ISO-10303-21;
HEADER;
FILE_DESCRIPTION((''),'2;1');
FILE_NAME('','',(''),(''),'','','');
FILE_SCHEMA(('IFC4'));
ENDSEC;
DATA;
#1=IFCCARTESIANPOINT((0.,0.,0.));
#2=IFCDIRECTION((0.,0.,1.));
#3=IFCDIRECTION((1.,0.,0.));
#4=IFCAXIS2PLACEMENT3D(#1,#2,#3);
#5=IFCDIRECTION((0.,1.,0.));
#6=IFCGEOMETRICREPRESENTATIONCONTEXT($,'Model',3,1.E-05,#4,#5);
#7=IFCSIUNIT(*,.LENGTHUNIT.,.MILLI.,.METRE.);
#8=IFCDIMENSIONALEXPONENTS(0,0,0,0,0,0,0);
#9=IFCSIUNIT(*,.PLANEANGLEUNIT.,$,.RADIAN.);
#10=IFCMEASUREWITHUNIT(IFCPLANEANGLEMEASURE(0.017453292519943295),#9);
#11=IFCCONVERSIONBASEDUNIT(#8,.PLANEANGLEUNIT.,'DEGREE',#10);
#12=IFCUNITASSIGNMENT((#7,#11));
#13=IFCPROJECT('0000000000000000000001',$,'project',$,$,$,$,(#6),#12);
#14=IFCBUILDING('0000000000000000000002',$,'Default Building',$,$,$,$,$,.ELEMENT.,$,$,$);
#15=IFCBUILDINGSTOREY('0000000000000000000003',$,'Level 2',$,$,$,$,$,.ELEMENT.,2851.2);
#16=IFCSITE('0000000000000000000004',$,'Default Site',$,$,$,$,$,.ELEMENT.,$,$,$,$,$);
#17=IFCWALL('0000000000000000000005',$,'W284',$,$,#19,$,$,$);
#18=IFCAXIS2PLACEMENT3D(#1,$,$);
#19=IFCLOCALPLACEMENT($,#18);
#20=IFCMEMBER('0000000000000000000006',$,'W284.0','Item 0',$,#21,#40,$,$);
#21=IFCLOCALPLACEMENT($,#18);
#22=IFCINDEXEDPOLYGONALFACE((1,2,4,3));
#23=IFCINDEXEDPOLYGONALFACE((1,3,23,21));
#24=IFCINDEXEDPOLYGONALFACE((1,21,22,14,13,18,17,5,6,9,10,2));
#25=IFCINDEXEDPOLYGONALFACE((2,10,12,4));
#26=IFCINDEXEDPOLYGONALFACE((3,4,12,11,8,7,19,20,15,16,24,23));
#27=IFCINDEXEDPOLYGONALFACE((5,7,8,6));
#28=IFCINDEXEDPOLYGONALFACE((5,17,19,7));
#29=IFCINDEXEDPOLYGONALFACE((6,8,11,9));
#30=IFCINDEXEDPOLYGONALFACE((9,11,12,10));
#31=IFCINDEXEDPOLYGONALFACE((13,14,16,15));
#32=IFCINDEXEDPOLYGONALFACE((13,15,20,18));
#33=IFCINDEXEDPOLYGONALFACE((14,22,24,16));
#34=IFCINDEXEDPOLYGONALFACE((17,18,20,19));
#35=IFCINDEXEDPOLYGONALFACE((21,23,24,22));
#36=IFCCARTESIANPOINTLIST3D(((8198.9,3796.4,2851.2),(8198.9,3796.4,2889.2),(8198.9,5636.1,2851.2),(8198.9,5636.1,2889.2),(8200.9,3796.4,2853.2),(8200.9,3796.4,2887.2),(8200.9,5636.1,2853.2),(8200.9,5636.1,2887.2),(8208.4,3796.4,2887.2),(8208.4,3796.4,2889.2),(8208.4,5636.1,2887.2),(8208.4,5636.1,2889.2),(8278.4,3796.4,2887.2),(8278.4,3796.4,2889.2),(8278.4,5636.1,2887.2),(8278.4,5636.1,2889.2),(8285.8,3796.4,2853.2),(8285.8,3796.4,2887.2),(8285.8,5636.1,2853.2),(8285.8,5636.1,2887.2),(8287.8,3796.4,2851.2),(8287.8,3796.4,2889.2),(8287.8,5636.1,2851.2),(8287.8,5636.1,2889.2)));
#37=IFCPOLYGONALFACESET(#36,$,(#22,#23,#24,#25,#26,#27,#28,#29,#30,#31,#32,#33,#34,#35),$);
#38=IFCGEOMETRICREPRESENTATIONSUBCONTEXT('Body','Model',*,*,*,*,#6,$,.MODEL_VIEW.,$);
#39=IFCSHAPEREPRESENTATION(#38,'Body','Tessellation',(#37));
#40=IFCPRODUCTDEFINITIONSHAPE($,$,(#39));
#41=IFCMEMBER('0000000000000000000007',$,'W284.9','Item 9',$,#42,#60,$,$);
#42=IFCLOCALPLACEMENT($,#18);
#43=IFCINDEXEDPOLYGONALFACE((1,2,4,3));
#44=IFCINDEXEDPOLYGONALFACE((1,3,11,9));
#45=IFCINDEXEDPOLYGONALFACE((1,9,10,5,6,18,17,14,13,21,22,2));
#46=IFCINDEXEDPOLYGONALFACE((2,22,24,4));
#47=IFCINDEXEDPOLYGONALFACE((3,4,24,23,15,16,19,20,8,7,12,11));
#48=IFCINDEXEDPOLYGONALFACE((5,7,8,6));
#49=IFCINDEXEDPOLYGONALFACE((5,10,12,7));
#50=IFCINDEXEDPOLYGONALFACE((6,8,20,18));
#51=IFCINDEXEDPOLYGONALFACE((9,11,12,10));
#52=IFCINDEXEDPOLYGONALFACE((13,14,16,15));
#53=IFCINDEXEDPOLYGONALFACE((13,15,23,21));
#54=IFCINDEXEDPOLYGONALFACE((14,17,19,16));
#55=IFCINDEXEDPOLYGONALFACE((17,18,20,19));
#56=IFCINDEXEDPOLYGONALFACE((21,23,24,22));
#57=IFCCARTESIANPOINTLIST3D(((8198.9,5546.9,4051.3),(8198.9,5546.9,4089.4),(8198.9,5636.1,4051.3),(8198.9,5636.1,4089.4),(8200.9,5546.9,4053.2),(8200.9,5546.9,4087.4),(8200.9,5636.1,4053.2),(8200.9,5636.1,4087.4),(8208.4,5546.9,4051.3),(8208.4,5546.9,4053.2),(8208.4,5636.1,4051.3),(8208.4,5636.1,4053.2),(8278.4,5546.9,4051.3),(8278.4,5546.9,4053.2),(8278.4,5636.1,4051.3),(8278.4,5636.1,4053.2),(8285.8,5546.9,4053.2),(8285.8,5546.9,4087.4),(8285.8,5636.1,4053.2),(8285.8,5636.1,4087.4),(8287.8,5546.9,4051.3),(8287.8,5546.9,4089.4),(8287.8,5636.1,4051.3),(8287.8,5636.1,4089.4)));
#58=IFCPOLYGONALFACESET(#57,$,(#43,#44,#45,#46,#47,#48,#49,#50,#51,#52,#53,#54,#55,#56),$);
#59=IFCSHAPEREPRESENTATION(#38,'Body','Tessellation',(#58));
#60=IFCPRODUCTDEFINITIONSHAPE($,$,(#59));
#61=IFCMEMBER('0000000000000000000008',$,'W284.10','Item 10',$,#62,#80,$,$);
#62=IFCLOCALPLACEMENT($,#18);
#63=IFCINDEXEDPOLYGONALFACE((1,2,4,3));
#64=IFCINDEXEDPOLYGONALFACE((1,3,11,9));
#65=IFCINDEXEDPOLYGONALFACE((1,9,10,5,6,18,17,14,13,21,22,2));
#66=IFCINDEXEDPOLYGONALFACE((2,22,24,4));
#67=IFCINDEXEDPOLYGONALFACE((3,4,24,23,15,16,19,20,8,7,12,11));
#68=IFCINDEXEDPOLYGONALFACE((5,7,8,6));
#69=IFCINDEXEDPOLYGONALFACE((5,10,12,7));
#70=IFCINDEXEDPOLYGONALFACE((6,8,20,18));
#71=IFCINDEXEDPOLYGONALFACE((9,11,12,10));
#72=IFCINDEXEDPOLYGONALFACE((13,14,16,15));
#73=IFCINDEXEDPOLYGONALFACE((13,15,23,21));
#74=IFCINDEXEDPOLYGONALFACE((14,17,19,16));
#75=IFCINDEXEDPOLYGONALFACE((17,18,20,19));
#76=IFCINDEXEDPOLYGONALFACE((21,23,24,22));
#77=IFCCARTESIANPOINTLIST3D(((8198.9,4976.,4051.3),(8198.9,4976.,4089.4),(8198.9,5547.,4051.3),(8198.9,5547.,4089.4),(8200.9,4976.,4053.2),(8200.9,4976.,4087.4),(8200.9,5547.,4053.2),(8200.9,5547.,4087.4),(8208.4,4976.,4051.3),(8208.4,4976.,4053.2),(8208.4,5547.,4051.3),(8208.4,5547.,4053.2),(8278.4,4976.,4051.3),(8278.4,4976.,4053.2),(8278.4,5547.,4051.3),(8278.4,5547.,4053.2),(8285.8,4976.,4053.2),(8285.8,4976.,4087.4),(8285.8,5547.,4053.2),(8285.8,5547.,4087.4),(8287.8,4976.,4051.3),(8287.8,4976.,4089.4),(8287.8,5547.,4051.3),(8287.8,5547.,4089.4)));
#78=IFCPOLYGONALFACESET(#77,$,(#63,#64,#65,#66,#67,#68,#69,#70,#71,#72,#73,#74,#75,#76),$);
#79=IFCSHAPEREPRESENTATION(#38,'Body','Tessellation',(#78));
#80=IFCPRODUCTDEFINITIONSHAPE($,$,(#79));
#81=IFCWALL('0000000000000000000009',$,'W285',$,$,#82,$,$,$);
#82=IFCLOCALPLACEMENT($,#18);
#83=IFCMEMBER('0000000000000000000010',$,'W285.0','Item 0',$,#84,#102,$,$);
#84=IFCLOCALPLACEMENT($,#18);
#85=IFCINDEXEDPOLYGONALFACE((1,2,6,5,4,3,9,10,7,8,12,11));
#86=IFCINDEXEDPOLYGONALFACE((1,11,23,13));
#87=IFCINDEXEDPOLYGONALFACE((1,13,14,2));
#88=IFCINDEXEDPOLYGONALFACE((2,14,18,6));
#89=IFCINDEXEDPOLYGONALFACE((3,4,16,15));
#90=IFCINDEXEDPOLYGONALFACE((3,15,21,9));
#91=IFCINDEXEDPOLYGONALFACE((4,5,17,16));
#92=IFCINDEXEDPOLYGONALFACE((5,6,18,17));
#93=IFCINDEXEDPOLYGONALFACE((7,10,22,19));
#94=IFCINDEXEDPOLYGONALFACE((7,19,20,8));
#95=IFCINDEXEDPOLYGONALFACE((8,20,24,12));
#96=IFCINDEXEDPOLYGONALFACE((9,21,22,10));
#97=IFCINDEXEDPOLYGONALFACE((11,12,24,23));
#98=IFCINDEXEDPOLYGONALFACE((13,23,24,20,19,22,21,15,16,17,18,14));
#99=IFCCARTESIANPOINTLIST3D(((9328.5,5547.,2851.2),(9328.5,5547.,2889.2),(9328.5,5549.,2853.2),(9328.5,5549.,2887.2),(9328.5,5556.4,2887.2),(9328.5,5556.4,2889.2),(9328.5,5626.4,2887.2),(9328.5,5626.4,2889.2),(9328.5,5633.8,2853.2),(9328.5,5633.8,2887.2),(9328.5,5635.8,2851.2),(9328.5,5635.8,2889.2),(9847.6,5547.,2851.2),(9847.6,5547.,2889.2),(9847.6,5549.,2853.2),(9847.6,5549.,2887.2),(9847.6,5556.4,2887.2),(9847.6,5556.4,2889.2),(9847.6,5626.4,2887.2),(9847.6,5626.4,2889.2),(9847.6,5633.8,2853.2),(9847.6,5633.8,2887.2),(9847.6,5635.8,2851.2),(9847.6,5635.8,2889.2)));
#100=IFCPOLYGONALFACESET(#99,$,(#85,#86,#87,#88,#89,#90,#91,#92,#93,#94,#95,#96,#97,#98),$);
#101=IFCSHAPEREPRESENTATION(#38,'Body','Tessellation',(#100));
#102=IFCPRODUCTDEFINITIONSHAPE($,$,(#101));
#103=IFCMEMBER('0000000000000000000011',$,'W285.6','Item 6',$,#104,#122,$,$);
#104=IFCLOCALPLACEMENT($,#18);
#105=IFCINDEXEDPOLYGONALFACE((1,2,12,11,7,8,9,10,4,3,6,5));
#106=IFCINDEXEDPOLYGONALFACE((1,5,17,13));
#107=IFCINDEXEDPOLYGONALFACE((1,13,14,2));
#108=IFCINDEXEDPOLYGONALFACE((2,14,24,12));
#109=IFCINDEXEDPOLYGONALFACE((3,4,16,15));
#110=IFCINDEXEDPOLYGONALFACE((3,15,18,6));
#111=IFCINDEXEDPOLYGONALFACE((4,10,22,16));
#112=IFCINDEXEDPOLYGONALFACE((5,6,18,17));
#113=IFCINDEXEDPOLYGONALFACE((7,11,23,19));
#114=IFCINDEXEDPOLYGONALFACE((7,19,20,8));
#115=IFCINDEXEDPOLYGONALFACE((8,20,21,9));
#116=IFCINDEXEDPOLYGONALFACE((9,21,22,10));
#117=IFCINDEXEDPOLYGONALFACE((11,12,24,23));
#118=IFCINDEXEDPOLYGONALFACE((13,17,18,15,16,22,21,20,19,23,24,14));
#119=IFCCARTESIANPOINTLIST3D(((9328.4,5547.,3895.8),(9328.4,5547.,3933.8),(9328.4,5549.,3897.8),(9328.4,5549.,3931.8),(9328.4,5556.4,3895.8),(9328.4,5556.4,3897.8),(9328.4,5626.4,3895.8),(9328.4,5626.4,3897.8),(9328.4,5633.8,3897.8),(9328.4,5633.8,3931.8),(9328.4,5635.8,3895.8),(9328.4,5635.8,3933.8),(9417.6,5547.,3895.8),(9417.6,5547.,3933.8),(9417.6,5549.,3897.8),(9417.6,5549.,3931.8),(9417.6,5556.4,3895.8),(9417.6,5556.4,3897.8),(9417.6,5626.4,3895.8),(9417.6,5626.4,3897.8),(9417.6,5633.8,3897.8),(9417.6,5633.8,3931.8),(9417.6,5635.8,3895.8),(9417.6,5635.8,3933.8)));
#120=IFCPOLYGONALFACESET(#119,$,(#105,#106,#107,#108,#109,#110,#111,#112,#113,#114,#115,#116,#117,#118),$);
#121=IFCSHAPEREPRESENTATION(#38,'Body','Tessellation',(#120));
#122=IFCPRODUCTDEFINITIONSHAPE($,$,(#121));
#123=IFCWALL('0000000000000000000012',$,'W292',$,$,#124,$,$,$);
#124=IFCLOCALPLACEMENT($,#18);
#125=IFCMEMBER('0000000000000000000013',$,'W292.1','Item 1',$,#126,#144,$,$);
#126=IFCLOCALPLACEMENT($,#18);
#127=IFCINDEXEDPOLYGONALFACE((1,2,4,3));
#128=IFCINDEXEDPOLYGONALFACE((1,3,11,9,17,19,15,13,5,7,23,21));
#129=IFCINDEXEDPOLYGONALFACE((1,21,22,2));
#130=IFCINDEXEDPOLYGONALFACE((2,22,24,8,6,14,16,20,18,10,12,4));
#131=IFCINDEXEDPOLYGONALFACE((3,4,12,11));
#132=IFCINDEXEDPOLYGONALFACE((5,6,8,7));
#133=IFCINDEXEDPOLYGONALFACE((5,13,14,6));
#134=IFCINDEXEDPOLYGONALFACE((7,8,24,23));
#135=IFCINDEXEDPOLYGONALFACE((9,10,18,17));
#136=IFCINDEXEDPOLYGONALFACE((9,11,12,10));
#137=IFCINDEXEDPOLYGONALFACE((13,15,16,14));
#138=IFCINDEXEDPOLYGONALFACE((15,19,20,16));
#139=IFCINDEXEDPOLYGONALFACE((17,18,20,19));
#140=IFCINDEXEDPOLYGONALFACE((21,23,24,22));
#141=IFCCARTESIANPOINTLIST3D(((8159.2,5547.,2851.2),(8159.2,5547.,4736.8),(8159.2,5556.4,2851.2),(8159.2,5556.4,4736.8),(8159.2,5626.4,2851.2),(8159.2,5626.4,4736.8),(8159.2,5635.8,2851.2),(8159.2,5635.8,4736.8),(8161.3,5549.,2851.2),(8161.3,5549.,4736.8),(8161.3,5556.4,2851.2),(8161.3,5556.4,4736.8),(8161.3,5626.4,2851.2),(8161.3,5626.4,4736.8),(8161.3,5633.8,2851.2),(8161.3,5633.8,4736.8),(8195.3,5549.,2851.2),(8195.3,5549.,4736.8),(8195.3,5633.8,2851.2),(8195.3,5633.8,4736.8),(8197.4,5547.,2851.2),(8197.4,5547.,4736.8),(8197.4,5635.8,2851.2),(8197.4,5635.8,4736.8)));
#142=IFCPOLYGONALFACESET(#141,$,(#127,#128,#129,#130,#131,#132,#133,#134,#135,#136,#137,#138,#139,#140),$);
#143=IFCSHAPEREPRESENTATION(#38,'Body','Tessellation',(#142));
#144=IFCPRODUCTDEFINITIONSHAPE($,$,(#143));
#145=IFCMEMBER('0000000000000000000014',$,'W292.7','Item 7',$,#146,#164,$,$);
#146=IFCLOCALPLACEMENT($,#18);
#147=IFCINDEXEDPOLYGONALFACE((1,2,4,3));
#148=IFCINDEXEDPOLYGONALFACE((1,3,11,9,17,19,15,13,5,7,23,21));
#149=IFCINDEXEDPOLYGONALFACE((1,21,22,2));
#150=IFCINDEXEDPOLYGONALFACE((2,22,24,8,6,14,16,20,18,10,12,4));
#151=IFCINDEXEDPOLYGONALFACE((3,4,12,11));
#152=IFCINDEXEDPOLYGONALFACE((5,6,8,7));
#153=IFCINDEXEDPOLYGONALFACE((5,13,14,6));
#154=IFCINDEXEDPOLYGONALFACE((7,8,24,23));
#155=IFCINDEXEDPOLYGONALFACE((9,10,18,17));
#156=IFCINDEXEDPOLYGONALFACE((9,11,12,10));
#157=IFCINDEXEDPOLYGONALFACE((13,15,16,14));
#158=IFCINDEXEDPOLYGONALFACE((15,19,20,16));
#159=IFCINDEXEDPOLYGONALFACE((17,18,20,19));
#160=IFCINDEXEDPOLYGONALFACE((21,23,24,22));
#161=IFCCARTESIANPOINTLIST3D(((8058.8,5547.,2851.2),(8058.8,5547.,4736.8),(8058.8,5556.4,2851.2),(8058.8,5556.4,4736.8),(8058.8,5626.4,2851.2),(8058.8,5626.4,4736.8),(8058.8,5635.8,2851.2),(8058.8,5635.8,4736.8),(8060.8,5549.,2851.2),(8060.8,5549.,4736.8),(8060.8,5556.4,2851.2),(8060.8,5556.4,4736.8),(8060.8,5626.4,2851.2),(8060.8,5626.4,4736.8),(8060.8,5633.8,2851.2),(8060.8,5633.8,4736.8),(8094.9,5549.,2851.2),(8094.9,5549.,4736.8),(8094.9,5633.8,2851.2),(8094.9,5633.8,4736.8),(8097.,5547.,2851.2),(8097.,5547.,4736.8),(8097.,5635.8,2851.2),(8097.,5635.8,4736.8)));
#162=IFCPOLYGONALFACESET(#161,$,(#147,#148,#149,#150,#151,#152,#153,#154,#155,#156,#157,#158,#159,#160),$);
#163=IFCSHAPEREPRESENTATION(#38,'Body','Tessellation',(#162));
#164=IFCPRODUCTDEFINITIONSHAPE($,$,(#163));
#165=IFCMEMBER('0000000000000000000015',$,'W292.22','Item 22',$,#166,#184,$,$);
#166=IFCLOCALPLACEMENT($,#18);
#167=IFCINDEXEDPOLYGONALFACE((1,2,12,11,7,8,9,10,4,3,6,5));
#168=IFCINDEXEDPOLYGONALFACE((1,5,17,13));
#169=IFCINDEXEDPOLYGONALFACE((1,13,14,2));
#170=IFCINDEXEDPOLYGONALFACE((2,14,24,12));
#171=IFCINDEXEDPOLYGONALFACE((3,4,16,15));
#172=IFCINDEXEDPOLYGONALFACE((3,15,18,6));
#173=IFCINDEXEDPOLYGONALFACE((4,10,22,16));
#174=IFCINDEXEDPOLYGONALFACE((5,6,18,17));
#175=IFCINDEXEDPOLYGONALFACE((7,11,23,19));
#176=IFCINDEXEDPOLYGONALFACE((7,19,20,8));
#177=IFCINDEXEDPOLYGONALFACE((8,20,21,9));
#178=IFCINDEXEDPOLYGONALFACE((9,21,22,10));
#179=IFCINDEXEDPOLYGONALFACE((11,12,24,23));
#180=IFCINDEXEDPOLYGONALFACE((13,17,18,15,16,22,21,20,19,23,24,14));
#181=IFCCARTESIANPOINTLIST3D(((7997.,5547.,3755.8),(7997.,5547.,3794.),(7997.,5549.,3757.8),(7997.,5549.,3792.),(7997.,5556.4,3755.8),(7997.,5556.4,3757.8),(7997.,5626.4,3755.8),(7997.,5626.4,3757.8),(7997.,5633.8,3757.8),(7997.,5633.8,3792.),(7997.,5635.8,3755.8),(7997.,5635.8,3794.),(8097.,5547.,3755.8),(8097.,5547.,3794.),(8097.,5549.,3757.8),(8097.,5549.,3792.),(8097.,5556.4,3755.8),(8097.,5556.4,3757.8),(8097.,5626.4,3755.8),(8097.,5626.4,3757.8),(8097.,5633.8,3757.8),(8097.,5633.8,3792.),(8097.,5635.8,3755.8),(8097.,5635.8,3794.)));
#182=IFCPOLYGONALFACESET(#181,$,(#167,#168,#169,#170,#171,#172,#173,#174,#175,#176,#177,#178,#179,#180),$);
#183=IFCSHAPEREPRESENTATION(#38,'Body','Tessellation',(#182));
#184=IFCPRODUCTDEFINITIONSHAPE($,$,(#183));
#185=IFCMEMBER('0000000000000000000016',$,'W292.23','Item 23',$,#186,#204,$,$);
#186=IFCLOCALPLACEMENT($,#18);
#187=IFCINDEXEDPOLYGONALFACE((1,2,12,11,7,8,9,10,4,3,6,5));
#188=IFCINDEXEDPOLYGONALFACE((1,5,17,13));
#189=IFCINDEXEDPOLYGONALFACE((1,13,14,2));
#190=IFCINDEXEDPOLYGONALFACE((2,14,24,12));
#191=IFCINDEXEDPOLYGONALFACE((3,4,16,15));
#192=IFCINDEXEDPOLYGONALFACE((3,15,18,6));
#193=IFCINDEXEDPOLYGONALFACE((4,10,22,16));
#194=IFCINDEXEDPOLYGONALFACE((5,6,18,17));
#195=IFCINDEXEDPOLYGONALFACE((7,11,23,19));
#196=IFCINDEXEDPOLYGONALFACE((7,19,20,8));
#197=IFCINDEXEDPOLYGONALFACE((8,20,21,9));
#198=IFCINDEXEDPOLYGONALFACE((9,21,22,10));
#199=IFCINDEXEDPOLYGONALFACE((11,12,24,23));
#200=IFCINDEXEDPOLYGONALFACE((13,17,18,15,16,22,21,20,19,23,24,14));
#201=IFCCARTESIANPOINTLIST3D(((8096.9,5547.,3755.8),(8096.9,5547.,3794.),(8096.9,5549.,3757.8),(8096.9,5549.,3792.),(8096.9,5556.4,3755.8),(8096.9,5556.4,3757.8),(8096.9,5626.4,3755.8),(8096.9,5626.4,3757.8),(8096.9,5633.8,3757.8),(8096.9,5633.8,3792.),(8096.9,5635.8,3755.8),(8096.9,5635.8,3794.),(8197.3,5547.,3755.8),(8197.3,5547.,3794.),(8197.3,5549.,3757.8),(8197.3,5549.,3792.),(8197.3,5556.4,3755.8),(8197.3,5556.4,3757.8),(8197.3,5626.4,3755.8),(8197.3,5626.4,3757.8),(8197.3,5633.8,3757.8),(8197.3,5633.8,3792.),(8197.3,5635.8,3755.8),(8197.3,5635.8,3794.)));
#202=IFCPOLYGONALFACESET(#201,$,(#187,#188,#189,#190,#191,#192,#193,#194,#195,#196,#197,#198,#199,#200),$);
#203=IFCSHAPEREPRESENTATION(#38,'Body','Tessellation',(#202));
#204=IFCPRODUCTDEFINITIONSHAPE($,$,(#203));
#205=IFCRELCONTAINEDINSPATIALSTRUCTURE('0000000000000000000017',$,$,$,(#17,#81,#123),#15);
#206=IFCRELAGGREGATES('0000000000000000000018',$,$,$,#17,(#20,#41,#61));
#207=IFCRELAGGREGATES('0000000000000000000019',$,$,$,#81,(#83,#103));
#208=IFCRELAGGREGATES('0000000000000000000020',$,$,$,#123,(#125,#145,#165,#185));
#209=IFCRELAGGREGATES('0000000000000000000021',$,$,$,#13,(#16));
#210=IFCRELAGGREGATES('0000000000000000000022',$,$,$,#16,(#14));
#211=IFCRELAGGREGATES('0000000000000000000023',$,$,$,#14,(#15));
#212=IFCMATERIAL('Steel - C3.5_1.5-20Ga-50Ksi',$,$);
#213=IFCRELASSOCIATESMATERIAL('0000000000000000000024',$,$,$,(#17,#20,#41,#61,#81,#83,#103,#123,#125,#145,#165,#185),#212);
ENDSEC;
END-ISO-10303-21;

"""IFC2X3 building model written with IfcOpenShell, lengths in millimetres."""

from ifc_helpers import new_model, entity, si_unit, converted_unit, direction, frame, origin, origin_with_axes, origin_2d_with_axis, place, context, subcontext, project, spatial, c_section, extrude, material, element, aggregate, save


model = new_model("IFC2X3")

# Units and contexts
model_context = context("Model", 3, precision=1e-05, world=origin_with_axes(), true_north=direction((0.0, 1.0, 0.0)))
body_context = subcontext(model_context, "Body", "Model", "MODEL_VIEW")
ifc_project = project(units=[si_unit("LENGTHUNIT", "METRE", prefix="MILLI"), converted_unit("PLANEANGLEUNIT", "DEGREE", entity("IfcPlaneAngleMeasure", 0.017453292519943295), si_unit("PLANEANGLEUNIT", "RADIAN"), dimensions=[0, 0, 0, 0, 0, 0, 0])], contexts=[model_context])

# Site, building, storey
site = spatial("IfcSite", under=ifc_project, Name="Default Site", CompositionType="ELEMENT")
building = spatial("IfcBuilding", under=site, Name="Default Building", CompositionType="ELEMENT")
storey = spatial("IfcBuildingStorey", under=building, Name="Level 2", CompositionType="ELEMENT", Elevation=2851.2)

# Walls, members
ifc_material_1 = material(Name="Steel - C3.5_1.5-20Ga-50Ksi")
wall_1 = element("IfcWall", 1, inside=storey, material=ifc_material_1, Name="W284")
member_1_placement = place(None, frame((8243.4, 5636.1, 2870.2), z_axis=(0.0, -1.0, 0.0), x_axis=(0.0, 0.0, 1.0)))
member_1 = element("IfcMember", 2, at=member_1_placement, material=ifc_material_1, Name="W284.0", Description="Item 0", context=body_context, shape_type="SweptSolid", body=[
    extrude(c_section(Depth=88.9, Width=38.1, WallThickness=2.0, Girth=9.5, at=origin_2d_with_axis()), origin(), (0.0, 0.0, 1.0), 1839.7),
])
member_2_placement = place(None, frame((8243.4, 5546.9, 4070.3), z_axis=(0.0, 1.0, 0.0), x_axis=(0.0, 0.0, -1.0)))
member_2 = element("IfcMember", 3, at=member_2_placement, material=ifc_material_1, Name="W284.9", Description="Item 9", context=body_context, shape_type="SweptSolid", body=[
    extrude(c_section(Depth=88.9, Width=38.1, WallThickness=2.0, Girth=9.5, at=origin_2d_with_axis()), origin(), (0.0, 0.0, 1.0), 89.2),
])
member_3_placement = place(None, frame((8243.4, 4976.0, 4070.3), z_axis=(0.0, 1.0, 0.0), x_axis=(0.0, 0.0, -1.0)))
member_3 = element("IfcMember", 4, at=member_3_placement, material=ifc_material_1, Name="W284.10", Description="Item 10", context=body_context, shape_type="SweptSolid", body=[
    extrude(c_section(Depth=88.9, Width=38.1, WallThickness=2.0, Girth=9.5, at=origin_2d_with_axis()), origin(), (0.0, 0.0, 1.0), 571.0),
])
aggregate(wall_1, [member_1, member_2, member_3])
wall_2 = element("IfcWall", 5, inside=storey, material=ifc_material_1, Name="W285")
member_4_placement = place(None, frame((9328.5, 5591.4, 2870.2), z_axis=(1.0, 0.0, 0.0), x_axis=(0.0, 0.0, 1.0)))
member_4 = element("IfcMember", 6, at=member_4_placement, material=ifc_material_1, Name="W285.0", Description="Item 0", context=body_context, shape_type="SweptSolid", body=[
    extrude(c_section(Depth=88.9, Width=38.1, WallThickness=2.0, Girth=9.5, at=origin_2d_with_axis()), origin(), (0.0, 0.0, 1.0), 519.1),
])
member_5_placement = place(None, frame((9417.6, 5591.4, 3914.8), z_axis=(-1.0, 0.0, 0.0), x_axis=(0.0, 0.0, -1.0)))
member_5 = element("IfcMember", 7, at=member_5_placement, material=ifc_material_1, Name="W285.6", Description="Item 6", context=body_context, shape_type="SweptSolid", body=[
    extrude(c_section(Depth=88.9, Width=38.1, WallThickness=2.0, Girth=9.5, at=origin_2d_with_axis()), origin(), (0.0, 0.0, 1.0), 89.2),
])
aggregate(wall_2, [member_4, member_5])
wall_3 = element("IfcWall", 8, inside=storey, material=ifc_material_1, Name="W292")
member_6_placement = place(None, frame((8178.3, 5591.4, 2851.2), z_axis=(0.0, 0.0, 1.0), x_axis=(-1.0, 0.0, 0.0)))
member_6 = element("IfcMember", 9, at=member_6_placement, material=ifc_material_1, Name="W292.1", Description="Item 1", context=body_context, shape_type="SweptSolid", body=[
    extrude(c_section(Depth=88.9, Width=38.1, WallThickness=2.0, Girth=9.5, at=origin_2d_with_axis()), origin(), (0.0, 0.0, 1.0), 1885.6),
])
member_7_placement = place(None, frame((8077.9, 5591.4, 2851.2), z_axis=(0.0, 0.0, 1.0), x_axis=(-1.0, 0.0, 0.0)))
member_7 = element("IfcMember", 10, at=member_7_placement, material=ifc_material_1, Name="W292.7", Description="Item 7", context=body_context, shape_type="SweptSolid", body=[
    extrude(c_section(Depth=88.9, Width=38.1, WallThickness=2.0, Girth=9.5, at=origin_2d_with_axis()), origin(), (0.0, 0.0, 1.0), 1885.6),
])
member_8_placement = place(None, frame((8097.0, 5591.4, 3774.9), z_axis=(-1.0, 0.0, 0.0), x_axis=(0.0, 0.0, -1.0)))
member_8 = element("IfcMember", 11, at=member_8_placement, material=ifc_material_1, Name="W292.22", Description="Item 22", context=body_context, shape_type="SweptSolid", body=[
    extrude(c_section(Depth=88.9, Width=38.1, WallThickness=2.0, Girth=9.5, at=origin_2d_with_axis()), origin(), (0.0, 0.0, 1.0), 100.0),
])
member_9_placement = place(None, frame((8197.3, 5591.4, 3774.9), z_axis=(-1.0, 0.0, 0.0), x_axis=(0.0, 0.0, -1.0)))
member_9 = element("IfcMember", 12, at=member_9_placement, material=ifc_material_1, Name="W292.23", Description="Item 23", context=body_context, shape_type="SweptSolid", body=[
    extrude(c_section(Depth=88.9, Width=38.1, WallThickness=2.0, Girth=9.5, at=origin_2d_with_axis()), origin(), (0.0, 0.0, 1.0), 100.4),
])
aggregate(wall_3, [member_6, member_7, member_8, member_9])

save(model, "model.ifc")
